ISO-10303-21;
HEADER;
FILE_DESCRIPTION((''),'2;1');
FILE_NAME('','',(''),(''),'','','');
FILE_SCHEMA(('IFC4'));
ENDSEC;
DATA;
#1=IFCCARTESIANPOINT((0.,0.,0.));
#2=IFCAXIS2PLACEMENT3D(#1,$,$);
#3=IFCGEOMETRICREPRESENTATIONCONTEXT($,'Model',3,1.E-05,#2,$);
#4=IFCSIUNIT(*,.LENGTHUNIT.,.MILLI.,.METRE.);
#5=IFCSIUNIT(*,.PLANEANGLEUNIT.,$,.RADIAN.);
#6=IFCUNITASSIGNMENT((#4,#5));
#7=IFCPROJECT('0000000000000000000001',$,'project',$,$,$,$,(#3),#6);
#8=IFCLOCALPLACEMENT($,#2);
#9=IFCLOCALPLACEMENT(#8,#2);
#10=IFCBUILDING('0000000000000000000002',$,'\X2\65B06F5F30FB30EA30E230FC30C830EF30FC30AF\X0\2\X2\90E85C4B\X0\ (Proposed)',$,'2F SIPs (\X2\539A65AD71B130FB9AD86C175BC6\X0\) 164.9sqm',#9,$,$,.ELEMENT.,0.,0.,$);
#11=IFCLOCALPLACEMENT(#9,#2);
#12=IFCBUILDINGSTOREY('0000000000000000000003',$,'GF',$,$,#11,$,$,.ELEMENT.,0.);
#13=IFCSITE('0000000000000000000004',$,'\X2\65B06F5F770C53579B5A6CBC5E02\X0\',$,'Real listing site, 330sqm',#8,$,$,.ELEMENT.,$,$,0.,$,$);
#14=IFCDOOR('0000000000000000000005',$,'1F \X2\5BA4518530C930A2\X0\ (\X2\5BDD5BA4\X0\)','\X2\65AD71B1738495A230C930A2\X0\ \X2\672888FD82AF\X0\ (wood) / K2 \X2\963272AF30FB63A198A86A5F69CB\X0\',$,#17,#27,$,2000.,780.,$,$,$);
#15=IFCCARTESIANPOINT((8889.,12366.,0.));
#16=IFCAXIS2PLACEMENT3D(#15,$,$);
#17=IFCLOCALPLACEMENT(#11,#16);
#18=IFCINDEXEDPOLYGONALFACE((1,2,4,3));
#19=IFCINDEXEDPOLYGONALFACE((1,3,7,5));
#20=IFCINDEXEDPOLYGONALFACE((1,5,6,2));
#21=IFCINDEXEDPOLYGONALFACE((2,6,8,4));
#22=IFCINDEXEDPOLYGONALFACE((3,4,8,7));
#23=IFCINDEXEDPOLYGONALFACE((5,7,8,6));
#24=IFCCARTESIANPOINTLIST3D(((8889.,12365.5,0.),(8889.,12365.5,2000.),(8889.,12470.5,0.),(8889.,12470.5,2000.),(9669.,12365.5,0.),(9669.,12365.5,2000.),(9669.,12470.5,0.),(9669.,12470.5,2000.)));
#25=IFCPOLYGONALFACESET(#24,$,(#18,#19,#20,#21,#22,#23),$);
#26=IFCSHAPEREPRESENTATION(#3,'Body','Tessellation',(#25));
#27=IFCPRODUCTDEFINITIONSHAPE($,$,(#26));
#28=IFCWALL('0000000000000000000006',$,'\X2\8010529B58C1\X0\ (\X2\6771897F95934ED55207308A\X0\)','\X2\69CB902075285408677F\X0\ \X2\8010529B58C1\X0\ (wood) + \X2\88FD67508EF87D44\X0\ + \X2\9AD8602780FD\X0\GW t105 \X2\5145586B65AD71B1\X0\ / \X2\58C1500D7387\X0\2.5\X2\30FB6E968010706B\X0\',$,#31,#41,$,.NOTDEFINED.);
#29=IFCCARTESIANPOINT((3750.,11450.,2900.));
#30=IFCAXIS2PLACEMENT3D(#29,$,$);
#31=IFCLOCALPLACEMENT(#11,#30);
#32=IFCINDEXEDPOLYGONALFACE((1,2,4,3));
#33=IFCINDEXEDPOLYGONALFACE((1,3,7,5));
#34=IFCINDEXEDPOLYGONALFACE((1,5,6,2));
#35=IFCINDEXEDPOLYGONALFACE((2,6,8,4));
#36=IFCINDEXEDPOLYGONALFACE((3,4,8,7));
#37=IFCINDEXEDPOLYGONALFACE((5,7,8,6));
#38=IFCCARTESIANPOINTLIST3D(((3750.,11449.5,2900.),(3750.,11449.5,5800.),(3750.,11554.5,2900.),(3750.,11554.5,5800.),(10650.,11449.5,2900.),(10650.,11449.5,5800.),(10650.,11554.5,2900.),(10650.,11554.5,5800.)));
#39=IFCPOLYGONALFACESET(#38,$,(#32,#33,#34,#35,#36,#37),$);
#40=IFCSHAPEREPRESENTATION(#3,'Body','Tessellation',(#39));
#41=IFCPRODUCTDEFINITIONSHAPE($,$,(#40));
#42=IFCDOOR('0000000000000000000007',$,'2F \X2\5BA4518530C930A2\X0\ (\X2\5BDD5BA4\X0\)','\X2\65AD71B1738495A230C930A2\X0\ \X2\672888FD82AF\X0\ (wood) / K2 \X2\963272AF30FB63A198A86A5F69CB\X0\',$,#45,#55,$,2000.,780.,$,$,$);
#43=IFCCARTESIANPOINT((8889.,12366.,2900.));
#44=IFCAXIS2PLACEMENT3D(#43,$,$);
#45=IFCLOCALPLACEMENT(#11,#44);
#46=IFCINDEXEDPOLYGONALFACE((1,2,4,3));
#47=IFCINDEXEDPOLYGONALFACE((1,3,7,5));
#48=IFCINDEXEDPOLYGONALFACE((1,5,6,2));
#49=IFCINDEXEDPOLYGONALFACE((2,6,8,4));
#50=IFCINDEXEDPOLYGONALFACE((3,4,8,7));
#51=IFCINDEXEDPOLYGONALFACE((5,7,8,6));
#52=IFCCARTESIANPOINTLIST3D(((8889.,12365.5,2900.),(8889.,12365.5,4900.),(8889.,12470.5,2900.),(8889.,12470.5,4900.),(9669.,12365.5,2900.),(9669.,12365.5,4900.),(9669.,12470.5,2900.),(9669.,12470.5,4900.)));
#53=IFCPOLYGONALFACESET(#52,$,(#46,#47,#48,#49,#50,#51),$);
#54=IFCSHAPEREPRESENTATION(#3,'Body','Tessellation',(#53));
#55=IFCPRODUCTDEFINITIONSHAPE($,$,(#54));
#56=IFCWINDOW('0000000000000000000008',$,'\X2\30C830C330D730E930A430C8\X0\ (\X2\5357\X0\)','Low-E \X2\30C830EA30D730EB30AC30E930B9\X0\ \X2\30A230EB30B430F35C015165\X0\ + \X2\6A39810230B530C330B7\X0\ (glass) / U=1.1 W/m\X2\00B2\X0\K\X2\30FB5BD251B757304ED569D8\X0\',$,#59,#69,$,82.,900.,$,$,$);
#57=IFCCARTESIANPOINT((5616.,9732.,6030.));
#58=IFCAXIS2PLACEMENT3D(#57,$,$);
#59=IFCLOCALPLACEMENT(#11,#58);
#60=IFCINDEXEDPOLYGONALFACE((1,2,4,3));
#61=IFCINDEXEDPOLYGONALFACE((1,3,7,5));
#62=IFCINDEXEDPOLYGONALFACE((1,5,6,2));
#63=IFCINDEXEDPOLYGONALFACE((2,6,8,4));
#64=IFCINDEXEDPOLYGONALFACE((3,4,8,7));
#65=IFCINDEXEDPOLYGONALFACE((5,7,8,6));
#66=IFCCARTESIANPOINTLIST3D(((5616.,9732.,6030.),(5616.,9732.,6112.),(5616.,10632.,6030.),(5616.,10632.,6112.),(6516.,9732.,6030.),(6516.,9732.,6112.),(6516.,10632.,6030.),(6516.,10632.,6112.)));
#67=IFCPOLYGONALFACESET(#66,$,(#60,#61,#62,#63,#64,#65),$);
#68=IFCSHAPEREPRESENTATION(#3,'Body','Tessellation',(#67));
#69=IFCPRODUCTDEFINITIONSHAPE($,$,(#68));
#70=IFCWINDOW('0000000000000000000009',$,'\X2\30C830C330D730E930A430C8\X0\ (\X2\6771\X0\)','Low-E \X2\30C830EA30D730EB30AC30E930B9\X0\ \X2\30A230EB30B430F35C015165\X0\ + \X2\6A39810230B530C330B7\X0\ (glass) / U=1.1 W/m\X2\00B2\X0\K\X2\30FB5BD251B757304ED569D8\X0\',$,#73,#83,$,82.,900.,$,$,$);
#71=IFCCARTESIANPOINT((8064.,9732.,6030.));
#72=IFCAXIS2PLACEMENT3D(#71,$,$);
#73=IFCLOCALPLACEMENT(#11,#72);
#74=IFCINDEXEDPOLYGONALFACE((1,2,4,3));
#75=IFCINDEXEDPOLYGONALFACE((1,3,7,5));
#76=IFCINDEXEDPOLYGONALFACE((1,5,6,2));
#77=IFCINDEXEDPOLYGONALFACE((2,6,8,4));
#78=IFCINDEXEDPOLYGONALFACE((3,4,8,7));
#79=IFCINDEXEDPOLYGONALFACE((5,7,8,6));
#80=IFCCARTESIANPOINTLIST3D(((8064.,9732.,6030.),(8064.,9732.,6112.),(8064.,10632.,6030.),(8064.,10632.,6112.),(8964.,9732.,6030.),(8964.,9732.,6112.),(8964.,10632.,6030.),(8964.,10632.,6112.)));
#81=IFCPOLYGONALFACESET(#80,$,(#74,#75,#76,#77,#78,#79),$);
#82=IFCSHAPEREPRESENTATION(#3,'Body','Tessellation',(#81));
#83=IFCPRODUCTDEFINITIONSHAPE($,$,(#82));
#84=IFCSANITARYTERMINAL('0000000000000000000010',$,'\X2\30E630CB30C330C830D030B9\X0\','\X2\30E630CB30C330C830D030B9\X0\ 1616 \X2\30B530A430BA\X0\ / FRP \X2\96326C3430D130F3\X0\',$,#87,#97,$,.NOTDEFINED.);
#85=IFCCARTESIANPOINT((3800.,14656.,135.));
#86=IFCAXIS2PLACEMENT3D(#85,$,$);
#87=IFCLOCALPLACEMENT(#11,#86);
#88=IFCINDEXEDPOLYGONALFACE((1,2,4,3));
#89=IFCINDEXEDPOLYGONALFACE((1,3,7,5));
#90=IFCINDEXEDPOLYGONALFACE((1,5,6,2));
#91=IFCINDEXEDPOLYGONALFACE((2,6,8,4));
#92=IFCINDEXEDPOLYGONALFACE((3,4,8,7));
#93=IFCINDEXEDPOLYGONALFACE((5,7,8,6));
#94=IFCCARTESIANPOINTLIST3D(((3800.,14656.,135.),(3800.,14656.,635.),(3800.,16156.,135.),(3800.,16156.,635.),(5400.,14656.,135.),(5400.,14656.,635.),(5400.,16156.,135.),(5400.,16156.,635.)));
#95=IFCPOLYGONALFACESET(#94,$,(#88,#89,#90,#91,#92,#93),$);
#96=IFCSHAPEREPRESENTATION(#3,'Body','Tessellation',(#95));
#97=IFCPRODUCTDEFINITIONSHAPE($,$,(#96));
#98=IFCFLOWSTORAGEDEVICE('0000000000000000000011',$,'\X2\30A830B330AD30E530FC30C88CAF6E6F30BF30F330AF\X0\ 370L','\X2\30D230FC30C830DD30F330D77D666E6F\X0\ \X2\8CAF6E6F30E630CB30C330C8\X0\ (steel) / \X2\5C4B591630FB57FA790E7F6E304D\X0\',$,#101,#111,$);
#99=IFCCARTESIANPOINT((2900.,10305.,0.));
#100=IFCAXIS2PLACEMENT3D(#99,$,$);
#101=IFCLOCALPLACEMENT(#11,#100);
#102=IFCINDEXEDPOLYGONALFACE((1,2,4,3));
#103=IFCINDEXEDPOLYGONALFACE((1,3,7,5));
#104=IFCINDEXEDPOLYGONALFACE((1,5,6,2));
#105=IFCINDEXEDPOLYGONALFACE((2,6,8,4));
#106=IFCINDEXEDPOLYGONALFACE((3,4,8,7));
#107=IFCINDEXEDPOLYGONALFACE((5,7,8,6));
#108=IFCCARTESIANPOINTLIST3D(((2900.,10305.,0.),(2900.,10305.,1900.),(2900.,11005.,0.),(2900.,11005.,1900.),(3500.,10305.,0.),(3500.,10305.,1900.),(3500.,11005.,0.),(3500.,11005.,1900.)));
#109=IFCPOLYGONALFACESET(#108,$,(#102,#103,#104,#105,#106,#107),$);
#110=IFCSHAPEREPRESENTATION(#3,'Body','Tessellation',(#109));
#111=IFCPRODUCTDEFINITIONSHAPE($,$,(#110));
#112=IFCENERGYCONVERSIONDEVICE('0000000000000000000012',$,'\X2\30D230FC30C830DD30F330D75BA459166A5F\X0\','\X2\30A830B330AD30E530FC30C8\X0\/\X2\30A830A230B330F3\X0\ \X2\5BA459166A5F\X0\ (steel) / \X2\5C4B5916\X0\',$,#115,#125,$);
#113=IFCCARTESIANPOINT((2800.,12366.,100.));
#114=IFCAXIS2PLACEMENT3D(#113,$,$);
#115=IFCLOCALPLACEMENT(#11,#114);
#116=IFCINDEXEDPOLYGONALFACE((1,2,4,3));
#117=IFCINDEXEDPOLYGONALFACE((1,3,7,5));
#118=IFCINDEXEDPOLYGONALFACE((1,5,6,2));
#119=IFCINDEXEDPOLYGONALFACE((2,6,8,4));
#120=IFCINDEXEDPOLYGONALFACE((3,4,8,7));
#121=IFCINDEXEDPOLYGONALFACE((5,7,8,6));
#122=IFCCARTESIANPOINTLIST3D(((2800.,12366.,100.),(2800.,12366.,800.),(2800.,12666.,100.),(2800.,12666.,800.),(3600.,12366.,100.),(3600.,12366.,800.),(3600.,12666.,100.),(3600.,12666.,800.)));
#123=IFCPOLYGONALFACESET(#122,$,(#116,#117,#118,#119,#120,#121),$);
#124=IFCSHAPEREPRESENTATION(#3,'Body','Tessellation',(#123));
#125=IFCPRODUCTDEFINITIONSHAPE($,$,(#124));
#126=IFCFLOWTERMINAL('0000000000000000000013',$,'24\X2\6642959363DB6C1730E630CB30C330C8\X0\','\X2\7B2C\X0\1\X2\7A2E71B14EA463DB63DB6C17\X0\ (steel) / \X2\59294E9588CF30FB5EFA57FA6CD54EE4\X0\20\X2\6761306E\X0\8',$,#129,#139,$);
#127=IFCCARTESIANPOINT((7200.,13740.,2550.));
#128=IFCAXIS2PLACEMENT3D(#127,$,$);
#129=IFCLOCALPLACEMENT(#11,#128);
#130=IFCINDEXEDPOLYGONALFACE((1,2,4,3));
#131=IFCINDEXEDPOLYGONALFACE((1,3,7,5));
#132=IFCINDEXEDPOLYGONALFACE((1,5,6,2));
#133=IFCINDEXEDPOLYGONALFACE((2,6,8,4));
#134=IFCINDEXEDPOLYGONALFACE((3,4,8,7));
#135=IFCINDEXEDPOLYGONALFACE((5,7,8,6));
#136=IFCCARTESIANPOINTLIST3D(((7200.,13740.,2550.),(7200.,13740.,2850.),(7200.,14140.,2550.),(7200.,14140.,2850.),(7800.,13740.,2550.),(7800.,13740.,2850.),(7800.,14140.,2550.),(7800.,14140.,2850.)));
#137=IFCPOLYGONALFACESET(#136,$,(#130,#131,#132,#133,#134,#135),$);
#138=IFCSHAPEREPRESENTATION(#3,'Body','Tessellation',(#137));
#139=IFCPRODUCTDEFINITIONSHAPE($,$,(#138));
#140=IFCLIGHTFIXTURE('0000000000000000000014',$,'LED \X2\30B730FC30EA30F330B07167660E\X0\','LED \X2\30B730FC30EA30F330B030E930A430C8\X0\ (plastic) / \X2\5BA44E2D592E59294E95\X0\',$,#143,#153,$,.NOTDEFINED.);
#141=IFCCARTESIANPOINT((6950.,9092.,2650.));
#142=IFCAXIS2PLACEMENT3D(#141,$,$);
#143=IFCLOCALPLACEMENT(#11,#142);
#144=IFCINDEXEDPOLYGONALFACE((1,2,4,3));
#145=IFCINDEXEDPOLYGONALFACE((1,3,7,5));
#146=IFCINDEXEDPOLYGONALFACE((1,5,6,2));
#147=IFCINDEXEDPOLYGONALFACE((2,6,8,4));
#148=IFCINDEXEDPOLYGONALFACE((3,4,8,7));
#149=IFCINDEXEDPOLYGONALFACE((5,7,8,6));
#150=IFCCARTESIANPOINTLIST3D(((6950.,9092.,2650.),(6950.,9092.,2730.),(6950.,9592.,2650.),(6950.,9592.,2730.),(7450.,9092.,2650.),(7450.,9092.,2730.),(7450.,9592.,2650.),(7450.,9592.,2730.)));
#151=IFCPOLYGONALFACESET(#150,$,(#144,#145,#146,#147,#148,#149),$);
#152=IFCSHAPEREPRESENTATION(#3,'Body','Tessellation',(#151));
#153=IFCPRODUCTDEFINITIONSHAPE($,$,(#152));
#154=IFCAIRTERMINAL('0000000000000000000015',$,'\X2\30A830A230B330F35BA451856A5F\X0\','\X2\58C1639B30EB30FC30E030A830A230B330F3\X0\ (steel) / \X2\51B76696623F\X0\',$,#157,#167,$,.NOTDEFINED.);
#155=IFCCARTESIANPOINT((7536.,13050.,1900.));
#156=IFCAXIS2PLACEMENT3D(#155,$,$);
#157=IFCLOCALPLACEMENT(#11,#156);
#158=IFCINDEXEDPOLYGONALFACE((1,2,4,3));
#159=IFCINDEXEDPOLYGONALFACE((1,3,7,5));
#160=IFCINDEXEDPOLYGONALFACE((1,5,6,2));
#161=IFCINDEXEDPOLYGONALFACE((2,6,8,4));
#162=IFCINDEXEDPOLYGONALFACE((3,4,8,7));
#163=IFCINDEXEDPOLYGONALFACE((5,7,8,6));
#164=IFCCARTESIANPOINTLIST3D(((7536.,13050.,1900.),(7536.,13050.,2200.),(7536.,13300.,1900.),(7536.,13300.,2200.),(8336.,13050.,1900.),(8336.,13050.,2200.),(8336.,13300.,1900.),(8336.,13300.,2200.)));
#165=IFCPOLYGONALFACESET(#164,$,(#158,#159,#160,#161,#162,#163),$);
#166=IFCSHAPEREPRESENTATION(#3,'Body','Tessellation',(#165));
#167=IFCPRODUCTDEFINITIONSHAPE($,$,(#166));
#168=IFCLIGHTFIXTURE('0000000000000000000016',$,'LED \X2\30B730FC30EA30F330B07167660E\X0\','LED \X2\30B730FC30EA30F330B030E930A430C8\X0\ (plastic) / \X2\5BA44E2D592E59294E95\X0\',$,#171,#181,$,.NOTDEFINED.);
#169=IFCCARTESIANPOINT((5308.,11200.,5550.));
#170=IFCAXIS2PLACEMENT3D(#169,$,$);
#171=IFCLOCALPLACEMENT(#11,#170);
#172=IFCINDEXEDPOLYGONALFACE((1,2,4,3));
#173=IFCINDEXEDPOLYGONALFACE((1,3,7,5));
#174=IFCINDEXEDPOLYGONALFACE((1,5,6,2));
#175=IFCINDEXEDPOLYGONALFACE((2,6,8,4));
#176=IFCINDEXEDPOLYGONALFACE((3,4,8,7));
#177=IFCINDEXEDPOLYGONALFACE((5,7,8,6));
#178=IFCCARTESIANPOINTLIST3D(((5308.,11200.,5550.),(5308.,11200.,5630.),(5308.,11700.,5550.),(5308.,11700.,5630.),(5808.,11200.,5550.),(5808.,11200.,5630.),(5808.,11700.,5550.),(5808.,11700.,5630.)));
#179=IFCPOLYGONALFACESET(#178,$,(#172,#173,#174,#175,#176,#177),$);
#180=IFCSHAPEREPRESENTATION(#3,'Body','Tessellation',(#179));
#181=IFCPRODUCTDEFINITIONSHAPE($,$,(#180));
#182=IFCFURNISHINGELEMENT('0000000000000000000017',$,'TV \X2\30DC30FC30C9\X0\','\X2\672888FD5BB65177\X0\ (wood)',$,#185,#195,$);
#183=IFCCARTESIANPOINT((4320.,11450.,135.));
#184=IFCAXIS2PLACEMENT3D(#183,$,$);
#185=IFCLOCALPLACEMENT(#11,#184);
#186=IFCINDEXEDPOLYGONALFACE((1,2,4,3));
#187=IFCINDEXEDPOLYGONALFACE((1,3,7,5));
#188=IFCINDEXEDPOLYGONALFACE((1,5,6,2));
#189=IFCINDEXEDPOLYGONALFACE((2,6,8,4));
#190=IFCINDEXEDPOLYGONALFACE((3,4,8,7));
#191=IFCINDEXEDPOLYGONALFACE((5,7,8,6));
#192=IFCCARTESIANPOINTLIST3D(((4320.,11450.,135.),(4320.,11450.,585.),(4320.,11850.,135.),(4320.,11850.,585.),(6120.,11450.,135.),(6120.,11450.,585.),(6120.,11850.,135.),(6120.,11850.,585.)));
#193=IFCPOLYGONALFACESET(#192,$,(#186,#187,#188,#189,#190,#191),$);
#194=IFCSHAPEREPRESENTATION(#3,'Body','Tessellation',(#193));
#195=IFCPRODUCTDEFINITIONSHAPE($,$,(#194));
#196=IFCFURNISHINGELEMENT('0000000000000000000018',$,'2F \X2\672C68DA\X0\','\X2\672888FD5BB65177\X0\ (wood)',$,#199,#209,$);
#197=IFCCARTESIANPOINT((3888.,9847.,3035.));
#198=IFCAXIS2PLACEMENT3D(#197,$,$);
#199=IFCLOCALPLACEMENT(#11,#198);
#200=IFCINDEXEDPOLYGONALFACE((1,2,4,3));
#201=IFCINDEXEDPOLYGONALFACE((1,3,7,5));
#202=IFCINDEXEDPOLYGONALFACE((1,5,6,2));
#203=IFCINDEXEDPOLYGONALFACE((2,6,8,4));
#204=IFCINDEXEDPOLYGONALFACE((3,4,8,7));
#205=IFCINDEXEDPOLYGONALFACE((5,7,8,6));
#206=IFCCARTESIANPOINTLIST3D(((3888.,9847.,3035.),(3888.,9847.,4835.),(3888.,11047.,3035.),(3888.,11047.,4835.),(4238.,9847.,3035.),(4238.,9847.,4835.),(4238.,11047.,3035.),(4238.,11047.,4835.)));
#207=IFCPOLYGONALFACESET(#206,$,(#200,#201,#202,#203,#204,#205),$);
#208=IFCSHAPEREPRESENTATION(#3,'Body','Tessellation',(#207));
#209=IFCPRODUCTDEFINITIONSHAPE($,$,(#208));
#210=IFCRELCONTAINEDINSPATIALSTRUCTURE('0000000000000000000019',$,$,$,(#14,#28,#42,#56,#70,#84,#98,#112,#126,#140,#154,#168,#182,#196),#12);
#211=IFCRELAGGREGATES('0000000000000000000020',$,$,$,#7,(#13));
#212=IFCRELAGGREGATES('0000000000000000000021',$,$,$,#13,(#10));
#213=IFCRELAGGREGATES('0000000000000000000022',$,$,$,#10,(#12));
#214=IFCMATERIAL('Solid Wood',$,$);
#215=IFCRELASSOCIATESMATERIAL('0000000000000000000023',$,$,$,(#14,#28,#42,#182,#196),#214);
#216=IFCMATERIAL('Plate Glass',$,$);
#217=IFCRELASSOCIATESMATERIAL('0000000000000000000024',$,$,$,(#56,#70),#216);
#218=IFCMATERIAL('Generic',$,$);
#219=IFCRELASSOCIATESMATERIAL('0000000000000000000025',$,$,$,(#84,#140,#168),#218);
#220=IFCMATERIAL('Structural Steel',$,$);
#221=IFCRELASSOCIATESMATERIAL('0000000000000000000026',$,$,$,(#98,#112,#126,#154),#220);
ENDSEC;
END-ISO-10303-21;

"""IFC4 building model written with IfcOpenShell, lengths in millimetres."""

from ifc_helpers import new_model, si_unit, frame, frame_2d, origin, place, context, project, spatial, rectangle, extrude, material, element, save


model = new_model("IFC4")

# Units and contexts
model_context = context("Model", 3, precision=1e-05, world=origin())
ifc_project = project(units=[si_unit("LENGTHUNIT", "METRE", prefix="MILLI"), si_unit("PLANEANGLEUNIT", "RADIAN")], contexts=[model_context])

# Site, building, storey
site_placement = place(None, origin())
site = spatial("IfcSite", under=ifc_project, at=site_placement, Name="新潟県南魚沼市", ObjectType="Real listing site, 330sqm", CompositionType="ELEMENT", RefElevation=0.0)
building_placement = place(site_placement, origin())
building = spatial("IfcBuilding", under=site, at=building_placement, Name="新潟・リモートワーク2部屋 (Proposed)", ObjectType="2F SIPs (厚断熱・高気密) 164.9sqm", CompositionType="ELEMENT", ElevationOfRefHeight=0.0, ElevationOfTerrain=0.0)
storey_placement = place(building_placement, origin())
storey = spatial("IfcBuildingStorey", under=building, at=storey_placement, Name="GF", CompositionType="ELEMENT", Elevation=0.0)

# Shared definitions
ifc_material_1 = material(Name="Solid Wood")

# Door
door_1_placement = place(storey_placement, frame((8889.0, 12366.0, 0.0)))
element("IfcDoor", 1, at=door_1_placement, inside=storey, material=ifc_material_1, Name="1F 室内ドア (寝室)", Description="断熱玄関ドア 木製芯 (wood) / K2 防犯・採風機構", OverallHeight=2000.0, OverallWidth=780.0, context=model_context, shape_type="SweptSolid", body=[
    extrude(rectangle(XDim=780.0, YDim=105.0, at=frame_2d((390.0, 52.0))), frame((8889.0, 12366.0, 0.0)), (0.0, 0.0, 1.0), 2000.0),
])

# Wall
wall_1_placement = place(storey_placement, frame((3750.0, 11450.0, 2900.0)))
element("IfcWall", 2, at=wall_1_placement, inside=storey, material=ifc_material_1, Name="耐力壁 (東西間仕切り)", Description="構造用合板 耐力壁 (wood) + 製材軸組 + 高性能GW t105 充填断熱 / 壁倍率2.5・準耐火", PredefinedType="NOTDEFINED", context=model_context, shape_type="SweptSolid", body=[
    extrude(rectangle(XDim=6900.0, YDim=105.0, at=frame_2d((3450.0, 52.0))), frame((3750.0, 11450.0, 2900.0)), (0.0, 0.0, 1.0), 2900.0),
])

# Door
door_2_placement = place(storey_placement, frame((8889.0, 12366.0, 2900.0)))
element("IfcDoor", 3, at=door_2_placement, inside=storey, material=ifc_material_1, Name="2F 室内ドア (寝室)", Description="断熱玄関ドア 木製芯 (wood) / K2 防犯・採風機構", OverallHeight=2000.0, OverallWidth=780.0, context=model_context, shape_type="SweptSolid", body=[
    extrude(rectangle(XDim=780.0, YDim=105.0, at=frame_2d((390.0, 52.0))), frame((8889.0, 12366.0, 2900.0)), (0.0, 0.0, 1.0), 2000.0),
])

# Windows
ifc_material_2 = material(Name="Plate Glass")
window_1_placement = place(storey_placement, frame((5616.0, 9732.0, 6030.0)))
element("IfcWindow", 4, at=window_1_placement, inside=storey, material=ifc_material_2, Name="トップライト (南)", Description="Low-E トリプルガラス アルゴン封入 + 樹脂サッシ (glass) / U=1.1 W/m²K・寒冷地仕様", OverallHeight=82.0, OverallWidth=900.0, context=model_context, shape_type="SweptSolid", body=[
    extrude(rectangle(XDim=900.0, YDim=900.0, at=frame_2d((450.0, 450.0))), frame((5616.0, 9732.0, 6030.0)), (0.0, 0.0, 1.0), 82.0),
])
window_2_placement = place(storey_placement, frame((8064.0, 9732.0, 6030.0)))
element("IfcWindow", 5, at=window_2_placement, inside=storey, material=ifc_material_2, Name="トップライト (東)", Description="Low-E トリプルガラス アルゴン封入 + 樹脂サッシ (glass) / U=1.1 W/m²K・寒冷地仕様", OverallHeight=82.0, OverallWidth=900.0, context=model_context, shape_type="SweptSolid", body=[
    extrude(rectangle(XDim=900.0, YDim=900.0, at=frame_2d((450.0, 450.0))), frame((8064.0, 9732.0, 6030.0)), (0.0, 0.0, 1.0), 82.0),
])

# Sanitary terminal
ifc_material_3 = material(Name="Generic")
sanitary_terminal_placement = place(storey_placement, frame((3800.0, 14656.0, 135.0)))
element("IfcSanitaryTerminal", 6, at=sanitary_terminal_placement, inside=storey, material=ifc_material_3, Name="ユニットバス", Description="ユニットバス 1616 サイズ / FRP 防水パン", PredefinedType="NOTDEFINED", context=model_context, shape_type="SweptSolid", body=[
    extrude(rectangle(XDim=1600.0, YDim=1500.0, at=frame_2d((800.0, 750.0))), frame((3800.0, 14656.0, 135.0)), (0.0, 0.0, 1.0), 500.0),
])

# Flow storage device
ifc_material_4 = material(Name="Structural Steel")
flow_storage_device_placement = place(storey_placement, frame((2900.0, 10305.0, 0.0)))
element("IfcFlowStorageDevice", 7, at=flow_storage_device_placement, inside=storey, material=ifc_material_4, Name="エコキュート貯湯タンク 370L", Description="ヒートポンプ給湯 貯湯ユニット (steel) / 屋外・基礎置き", context=model_context, shape_type="SweptSolid", body=[
    extrude(rectangle(XDim=600.0, YDim=700.0, at=frame_2d((300.0, 350.0))), frame((2900.0, 10305.0, 0.0)), (0.0, 0.0, 1.0), 1900.0),
])

# Energy conversion device
energy_conversion_device_placement = place(storey_placement, frame((2800.0, 12366.0, 100.0)))
element("IfcEnergyConversionDevice", 8, at=energy_conversion_device_placement, inside=storey, material=ifc_material_4, Name="ヒートポンプ室外機", Description="エコキュート/エアコン 室外機 (steel) / 屋外", context=model_context, shape_type="SweptSolid", body=[
    extrude(rectangle(XDim=800.0, YDim=300.0, at=frame_2d((400.0, 150.0))), frame((2800.0, 12366.0, 100.0)), (0.0, 0.0, 1.0), 700.0),
])

# Flow terminal
flow_terminal_placement = place(storey_placement, frame((7200.0, 13740.0, 2550.0)))
element("IfcFlowTerminal", 9, at=flow_terminal_placement, inside=storey, material=ifc_material_4, Name="24時間換気ユニット", Description="第1種熱交換換気 (steel) / 天井裏・建基法令20条の8", context=model_context, shape_type="SweptSolid", body=[
    extrude(rectangle(XDim=600.0, YDim=400.0, at=frame_2d((300.0, 200.0))), frame((7200.0, 13740.0, 2550.0)), (0.0, 0.0, 1.0), 300.0),
])

# Light fixture
light_fixture_1_placement = place(storey_placement, frame((6950.0, 9092.0, 2650.0)))
element("IfcLightFixture", 10, at=light_fixture_1_placement, inside=storey, material=ifc_material_3, Name="LED シーリング照明", Description="LED シーリングライト (plastic) / 室中央天井", PredefinedType="NOTDEFINED", context=model_context, shape_type="SweptSolid", body=[
    extrude(rectangle(XDim=500.0, YDim=500.0, at=frame_2d((250.0, 250.0))), frame((6950.0, 9092.0, 2650.0)), (0.0, 0.0, 1.0), 80.0),
])

# Air terminal
air_terminal_placement = place(storey_placement, frame((7536.0, 13050.0, 1900.0)))
element("IfcAirTerminal", 11, at=air_terminal_placement, inside=storey, material=ifc_material_4, Name="エアコン室内機", Description="壁掛ルームエアコン (steel) / 冷暖房", PredefinedType="NOTDEFINED", context=model_context, shape_type="SweptSolid", body=[
    extrude(rectangle(XDim=800.0, YDim=250.0, at=frame_2d((400.0, 125.0))), frame((7536.0, 13050.0, 1900.0)), (0.0, 0.0, 1.0), 300.0),
])

# Light fixture
light_fixture_2_placement = place(storey_placement, frame((5308.0, 11200.0, 5550.0)))
element("IfcLightFixture", 12, at=light_fixture_2_placement, inside=storey, material=ifc_material_3, Name="LED シーリング照明", Description="LED シーリングライト (plastic) / 室中央天井", PredefinedType="NOTDEFINED", context=model_context, shape_type="SweptSolid", body=[
    extrude(rectangle(XDim=500.0, YDim=500.0, at=frame_2d((250.0, 250.0))), frame((5308.0, 11200.0, 5550.0)), (0.0, 0.0, 1.0), 80.0),
])

# Furnishing elements
furnishing_1_placement = place(storey_placement, frame((4320.0, 11450.0, 135.0)))
element("IfcFurnishingElement", 13, at=furnishing_1_placement, inside=storey, material=ifc_material_1, Name="TV ボード", Description="木製家具 (wood)", context=model_context, shape_type="SweptSolid", body=[
    extrude(rectangle(XDim=1800.0, YDim=400.0, at=frame_2d((900.0, 200.0))), frame((4320.0, 11450.0, 135.0)), (0.0, 0.0, 1.0), 450.0),
])
furnishing_2_placement = place(storey_placement, frame((3888.0, 9847.0, 3035.0)))
element("IfcFurnishingElement", 14, at=furnishing_2_placement, inside=storey, material=ifc_material_1, Name="2F 本棚", Description="木製家具 (wood)", context=model_context, shape_type="SweptSolid", body=[
    extrude(rectangle(XDim=350.0, YDim=1200.0, at=frame_2d((175.0, 600.0))), frame((3888.0, 9847.0, 3035.0)), (0.0, 0.0, 1.0), 1800.0),
])

save(model, "model.ifc")
